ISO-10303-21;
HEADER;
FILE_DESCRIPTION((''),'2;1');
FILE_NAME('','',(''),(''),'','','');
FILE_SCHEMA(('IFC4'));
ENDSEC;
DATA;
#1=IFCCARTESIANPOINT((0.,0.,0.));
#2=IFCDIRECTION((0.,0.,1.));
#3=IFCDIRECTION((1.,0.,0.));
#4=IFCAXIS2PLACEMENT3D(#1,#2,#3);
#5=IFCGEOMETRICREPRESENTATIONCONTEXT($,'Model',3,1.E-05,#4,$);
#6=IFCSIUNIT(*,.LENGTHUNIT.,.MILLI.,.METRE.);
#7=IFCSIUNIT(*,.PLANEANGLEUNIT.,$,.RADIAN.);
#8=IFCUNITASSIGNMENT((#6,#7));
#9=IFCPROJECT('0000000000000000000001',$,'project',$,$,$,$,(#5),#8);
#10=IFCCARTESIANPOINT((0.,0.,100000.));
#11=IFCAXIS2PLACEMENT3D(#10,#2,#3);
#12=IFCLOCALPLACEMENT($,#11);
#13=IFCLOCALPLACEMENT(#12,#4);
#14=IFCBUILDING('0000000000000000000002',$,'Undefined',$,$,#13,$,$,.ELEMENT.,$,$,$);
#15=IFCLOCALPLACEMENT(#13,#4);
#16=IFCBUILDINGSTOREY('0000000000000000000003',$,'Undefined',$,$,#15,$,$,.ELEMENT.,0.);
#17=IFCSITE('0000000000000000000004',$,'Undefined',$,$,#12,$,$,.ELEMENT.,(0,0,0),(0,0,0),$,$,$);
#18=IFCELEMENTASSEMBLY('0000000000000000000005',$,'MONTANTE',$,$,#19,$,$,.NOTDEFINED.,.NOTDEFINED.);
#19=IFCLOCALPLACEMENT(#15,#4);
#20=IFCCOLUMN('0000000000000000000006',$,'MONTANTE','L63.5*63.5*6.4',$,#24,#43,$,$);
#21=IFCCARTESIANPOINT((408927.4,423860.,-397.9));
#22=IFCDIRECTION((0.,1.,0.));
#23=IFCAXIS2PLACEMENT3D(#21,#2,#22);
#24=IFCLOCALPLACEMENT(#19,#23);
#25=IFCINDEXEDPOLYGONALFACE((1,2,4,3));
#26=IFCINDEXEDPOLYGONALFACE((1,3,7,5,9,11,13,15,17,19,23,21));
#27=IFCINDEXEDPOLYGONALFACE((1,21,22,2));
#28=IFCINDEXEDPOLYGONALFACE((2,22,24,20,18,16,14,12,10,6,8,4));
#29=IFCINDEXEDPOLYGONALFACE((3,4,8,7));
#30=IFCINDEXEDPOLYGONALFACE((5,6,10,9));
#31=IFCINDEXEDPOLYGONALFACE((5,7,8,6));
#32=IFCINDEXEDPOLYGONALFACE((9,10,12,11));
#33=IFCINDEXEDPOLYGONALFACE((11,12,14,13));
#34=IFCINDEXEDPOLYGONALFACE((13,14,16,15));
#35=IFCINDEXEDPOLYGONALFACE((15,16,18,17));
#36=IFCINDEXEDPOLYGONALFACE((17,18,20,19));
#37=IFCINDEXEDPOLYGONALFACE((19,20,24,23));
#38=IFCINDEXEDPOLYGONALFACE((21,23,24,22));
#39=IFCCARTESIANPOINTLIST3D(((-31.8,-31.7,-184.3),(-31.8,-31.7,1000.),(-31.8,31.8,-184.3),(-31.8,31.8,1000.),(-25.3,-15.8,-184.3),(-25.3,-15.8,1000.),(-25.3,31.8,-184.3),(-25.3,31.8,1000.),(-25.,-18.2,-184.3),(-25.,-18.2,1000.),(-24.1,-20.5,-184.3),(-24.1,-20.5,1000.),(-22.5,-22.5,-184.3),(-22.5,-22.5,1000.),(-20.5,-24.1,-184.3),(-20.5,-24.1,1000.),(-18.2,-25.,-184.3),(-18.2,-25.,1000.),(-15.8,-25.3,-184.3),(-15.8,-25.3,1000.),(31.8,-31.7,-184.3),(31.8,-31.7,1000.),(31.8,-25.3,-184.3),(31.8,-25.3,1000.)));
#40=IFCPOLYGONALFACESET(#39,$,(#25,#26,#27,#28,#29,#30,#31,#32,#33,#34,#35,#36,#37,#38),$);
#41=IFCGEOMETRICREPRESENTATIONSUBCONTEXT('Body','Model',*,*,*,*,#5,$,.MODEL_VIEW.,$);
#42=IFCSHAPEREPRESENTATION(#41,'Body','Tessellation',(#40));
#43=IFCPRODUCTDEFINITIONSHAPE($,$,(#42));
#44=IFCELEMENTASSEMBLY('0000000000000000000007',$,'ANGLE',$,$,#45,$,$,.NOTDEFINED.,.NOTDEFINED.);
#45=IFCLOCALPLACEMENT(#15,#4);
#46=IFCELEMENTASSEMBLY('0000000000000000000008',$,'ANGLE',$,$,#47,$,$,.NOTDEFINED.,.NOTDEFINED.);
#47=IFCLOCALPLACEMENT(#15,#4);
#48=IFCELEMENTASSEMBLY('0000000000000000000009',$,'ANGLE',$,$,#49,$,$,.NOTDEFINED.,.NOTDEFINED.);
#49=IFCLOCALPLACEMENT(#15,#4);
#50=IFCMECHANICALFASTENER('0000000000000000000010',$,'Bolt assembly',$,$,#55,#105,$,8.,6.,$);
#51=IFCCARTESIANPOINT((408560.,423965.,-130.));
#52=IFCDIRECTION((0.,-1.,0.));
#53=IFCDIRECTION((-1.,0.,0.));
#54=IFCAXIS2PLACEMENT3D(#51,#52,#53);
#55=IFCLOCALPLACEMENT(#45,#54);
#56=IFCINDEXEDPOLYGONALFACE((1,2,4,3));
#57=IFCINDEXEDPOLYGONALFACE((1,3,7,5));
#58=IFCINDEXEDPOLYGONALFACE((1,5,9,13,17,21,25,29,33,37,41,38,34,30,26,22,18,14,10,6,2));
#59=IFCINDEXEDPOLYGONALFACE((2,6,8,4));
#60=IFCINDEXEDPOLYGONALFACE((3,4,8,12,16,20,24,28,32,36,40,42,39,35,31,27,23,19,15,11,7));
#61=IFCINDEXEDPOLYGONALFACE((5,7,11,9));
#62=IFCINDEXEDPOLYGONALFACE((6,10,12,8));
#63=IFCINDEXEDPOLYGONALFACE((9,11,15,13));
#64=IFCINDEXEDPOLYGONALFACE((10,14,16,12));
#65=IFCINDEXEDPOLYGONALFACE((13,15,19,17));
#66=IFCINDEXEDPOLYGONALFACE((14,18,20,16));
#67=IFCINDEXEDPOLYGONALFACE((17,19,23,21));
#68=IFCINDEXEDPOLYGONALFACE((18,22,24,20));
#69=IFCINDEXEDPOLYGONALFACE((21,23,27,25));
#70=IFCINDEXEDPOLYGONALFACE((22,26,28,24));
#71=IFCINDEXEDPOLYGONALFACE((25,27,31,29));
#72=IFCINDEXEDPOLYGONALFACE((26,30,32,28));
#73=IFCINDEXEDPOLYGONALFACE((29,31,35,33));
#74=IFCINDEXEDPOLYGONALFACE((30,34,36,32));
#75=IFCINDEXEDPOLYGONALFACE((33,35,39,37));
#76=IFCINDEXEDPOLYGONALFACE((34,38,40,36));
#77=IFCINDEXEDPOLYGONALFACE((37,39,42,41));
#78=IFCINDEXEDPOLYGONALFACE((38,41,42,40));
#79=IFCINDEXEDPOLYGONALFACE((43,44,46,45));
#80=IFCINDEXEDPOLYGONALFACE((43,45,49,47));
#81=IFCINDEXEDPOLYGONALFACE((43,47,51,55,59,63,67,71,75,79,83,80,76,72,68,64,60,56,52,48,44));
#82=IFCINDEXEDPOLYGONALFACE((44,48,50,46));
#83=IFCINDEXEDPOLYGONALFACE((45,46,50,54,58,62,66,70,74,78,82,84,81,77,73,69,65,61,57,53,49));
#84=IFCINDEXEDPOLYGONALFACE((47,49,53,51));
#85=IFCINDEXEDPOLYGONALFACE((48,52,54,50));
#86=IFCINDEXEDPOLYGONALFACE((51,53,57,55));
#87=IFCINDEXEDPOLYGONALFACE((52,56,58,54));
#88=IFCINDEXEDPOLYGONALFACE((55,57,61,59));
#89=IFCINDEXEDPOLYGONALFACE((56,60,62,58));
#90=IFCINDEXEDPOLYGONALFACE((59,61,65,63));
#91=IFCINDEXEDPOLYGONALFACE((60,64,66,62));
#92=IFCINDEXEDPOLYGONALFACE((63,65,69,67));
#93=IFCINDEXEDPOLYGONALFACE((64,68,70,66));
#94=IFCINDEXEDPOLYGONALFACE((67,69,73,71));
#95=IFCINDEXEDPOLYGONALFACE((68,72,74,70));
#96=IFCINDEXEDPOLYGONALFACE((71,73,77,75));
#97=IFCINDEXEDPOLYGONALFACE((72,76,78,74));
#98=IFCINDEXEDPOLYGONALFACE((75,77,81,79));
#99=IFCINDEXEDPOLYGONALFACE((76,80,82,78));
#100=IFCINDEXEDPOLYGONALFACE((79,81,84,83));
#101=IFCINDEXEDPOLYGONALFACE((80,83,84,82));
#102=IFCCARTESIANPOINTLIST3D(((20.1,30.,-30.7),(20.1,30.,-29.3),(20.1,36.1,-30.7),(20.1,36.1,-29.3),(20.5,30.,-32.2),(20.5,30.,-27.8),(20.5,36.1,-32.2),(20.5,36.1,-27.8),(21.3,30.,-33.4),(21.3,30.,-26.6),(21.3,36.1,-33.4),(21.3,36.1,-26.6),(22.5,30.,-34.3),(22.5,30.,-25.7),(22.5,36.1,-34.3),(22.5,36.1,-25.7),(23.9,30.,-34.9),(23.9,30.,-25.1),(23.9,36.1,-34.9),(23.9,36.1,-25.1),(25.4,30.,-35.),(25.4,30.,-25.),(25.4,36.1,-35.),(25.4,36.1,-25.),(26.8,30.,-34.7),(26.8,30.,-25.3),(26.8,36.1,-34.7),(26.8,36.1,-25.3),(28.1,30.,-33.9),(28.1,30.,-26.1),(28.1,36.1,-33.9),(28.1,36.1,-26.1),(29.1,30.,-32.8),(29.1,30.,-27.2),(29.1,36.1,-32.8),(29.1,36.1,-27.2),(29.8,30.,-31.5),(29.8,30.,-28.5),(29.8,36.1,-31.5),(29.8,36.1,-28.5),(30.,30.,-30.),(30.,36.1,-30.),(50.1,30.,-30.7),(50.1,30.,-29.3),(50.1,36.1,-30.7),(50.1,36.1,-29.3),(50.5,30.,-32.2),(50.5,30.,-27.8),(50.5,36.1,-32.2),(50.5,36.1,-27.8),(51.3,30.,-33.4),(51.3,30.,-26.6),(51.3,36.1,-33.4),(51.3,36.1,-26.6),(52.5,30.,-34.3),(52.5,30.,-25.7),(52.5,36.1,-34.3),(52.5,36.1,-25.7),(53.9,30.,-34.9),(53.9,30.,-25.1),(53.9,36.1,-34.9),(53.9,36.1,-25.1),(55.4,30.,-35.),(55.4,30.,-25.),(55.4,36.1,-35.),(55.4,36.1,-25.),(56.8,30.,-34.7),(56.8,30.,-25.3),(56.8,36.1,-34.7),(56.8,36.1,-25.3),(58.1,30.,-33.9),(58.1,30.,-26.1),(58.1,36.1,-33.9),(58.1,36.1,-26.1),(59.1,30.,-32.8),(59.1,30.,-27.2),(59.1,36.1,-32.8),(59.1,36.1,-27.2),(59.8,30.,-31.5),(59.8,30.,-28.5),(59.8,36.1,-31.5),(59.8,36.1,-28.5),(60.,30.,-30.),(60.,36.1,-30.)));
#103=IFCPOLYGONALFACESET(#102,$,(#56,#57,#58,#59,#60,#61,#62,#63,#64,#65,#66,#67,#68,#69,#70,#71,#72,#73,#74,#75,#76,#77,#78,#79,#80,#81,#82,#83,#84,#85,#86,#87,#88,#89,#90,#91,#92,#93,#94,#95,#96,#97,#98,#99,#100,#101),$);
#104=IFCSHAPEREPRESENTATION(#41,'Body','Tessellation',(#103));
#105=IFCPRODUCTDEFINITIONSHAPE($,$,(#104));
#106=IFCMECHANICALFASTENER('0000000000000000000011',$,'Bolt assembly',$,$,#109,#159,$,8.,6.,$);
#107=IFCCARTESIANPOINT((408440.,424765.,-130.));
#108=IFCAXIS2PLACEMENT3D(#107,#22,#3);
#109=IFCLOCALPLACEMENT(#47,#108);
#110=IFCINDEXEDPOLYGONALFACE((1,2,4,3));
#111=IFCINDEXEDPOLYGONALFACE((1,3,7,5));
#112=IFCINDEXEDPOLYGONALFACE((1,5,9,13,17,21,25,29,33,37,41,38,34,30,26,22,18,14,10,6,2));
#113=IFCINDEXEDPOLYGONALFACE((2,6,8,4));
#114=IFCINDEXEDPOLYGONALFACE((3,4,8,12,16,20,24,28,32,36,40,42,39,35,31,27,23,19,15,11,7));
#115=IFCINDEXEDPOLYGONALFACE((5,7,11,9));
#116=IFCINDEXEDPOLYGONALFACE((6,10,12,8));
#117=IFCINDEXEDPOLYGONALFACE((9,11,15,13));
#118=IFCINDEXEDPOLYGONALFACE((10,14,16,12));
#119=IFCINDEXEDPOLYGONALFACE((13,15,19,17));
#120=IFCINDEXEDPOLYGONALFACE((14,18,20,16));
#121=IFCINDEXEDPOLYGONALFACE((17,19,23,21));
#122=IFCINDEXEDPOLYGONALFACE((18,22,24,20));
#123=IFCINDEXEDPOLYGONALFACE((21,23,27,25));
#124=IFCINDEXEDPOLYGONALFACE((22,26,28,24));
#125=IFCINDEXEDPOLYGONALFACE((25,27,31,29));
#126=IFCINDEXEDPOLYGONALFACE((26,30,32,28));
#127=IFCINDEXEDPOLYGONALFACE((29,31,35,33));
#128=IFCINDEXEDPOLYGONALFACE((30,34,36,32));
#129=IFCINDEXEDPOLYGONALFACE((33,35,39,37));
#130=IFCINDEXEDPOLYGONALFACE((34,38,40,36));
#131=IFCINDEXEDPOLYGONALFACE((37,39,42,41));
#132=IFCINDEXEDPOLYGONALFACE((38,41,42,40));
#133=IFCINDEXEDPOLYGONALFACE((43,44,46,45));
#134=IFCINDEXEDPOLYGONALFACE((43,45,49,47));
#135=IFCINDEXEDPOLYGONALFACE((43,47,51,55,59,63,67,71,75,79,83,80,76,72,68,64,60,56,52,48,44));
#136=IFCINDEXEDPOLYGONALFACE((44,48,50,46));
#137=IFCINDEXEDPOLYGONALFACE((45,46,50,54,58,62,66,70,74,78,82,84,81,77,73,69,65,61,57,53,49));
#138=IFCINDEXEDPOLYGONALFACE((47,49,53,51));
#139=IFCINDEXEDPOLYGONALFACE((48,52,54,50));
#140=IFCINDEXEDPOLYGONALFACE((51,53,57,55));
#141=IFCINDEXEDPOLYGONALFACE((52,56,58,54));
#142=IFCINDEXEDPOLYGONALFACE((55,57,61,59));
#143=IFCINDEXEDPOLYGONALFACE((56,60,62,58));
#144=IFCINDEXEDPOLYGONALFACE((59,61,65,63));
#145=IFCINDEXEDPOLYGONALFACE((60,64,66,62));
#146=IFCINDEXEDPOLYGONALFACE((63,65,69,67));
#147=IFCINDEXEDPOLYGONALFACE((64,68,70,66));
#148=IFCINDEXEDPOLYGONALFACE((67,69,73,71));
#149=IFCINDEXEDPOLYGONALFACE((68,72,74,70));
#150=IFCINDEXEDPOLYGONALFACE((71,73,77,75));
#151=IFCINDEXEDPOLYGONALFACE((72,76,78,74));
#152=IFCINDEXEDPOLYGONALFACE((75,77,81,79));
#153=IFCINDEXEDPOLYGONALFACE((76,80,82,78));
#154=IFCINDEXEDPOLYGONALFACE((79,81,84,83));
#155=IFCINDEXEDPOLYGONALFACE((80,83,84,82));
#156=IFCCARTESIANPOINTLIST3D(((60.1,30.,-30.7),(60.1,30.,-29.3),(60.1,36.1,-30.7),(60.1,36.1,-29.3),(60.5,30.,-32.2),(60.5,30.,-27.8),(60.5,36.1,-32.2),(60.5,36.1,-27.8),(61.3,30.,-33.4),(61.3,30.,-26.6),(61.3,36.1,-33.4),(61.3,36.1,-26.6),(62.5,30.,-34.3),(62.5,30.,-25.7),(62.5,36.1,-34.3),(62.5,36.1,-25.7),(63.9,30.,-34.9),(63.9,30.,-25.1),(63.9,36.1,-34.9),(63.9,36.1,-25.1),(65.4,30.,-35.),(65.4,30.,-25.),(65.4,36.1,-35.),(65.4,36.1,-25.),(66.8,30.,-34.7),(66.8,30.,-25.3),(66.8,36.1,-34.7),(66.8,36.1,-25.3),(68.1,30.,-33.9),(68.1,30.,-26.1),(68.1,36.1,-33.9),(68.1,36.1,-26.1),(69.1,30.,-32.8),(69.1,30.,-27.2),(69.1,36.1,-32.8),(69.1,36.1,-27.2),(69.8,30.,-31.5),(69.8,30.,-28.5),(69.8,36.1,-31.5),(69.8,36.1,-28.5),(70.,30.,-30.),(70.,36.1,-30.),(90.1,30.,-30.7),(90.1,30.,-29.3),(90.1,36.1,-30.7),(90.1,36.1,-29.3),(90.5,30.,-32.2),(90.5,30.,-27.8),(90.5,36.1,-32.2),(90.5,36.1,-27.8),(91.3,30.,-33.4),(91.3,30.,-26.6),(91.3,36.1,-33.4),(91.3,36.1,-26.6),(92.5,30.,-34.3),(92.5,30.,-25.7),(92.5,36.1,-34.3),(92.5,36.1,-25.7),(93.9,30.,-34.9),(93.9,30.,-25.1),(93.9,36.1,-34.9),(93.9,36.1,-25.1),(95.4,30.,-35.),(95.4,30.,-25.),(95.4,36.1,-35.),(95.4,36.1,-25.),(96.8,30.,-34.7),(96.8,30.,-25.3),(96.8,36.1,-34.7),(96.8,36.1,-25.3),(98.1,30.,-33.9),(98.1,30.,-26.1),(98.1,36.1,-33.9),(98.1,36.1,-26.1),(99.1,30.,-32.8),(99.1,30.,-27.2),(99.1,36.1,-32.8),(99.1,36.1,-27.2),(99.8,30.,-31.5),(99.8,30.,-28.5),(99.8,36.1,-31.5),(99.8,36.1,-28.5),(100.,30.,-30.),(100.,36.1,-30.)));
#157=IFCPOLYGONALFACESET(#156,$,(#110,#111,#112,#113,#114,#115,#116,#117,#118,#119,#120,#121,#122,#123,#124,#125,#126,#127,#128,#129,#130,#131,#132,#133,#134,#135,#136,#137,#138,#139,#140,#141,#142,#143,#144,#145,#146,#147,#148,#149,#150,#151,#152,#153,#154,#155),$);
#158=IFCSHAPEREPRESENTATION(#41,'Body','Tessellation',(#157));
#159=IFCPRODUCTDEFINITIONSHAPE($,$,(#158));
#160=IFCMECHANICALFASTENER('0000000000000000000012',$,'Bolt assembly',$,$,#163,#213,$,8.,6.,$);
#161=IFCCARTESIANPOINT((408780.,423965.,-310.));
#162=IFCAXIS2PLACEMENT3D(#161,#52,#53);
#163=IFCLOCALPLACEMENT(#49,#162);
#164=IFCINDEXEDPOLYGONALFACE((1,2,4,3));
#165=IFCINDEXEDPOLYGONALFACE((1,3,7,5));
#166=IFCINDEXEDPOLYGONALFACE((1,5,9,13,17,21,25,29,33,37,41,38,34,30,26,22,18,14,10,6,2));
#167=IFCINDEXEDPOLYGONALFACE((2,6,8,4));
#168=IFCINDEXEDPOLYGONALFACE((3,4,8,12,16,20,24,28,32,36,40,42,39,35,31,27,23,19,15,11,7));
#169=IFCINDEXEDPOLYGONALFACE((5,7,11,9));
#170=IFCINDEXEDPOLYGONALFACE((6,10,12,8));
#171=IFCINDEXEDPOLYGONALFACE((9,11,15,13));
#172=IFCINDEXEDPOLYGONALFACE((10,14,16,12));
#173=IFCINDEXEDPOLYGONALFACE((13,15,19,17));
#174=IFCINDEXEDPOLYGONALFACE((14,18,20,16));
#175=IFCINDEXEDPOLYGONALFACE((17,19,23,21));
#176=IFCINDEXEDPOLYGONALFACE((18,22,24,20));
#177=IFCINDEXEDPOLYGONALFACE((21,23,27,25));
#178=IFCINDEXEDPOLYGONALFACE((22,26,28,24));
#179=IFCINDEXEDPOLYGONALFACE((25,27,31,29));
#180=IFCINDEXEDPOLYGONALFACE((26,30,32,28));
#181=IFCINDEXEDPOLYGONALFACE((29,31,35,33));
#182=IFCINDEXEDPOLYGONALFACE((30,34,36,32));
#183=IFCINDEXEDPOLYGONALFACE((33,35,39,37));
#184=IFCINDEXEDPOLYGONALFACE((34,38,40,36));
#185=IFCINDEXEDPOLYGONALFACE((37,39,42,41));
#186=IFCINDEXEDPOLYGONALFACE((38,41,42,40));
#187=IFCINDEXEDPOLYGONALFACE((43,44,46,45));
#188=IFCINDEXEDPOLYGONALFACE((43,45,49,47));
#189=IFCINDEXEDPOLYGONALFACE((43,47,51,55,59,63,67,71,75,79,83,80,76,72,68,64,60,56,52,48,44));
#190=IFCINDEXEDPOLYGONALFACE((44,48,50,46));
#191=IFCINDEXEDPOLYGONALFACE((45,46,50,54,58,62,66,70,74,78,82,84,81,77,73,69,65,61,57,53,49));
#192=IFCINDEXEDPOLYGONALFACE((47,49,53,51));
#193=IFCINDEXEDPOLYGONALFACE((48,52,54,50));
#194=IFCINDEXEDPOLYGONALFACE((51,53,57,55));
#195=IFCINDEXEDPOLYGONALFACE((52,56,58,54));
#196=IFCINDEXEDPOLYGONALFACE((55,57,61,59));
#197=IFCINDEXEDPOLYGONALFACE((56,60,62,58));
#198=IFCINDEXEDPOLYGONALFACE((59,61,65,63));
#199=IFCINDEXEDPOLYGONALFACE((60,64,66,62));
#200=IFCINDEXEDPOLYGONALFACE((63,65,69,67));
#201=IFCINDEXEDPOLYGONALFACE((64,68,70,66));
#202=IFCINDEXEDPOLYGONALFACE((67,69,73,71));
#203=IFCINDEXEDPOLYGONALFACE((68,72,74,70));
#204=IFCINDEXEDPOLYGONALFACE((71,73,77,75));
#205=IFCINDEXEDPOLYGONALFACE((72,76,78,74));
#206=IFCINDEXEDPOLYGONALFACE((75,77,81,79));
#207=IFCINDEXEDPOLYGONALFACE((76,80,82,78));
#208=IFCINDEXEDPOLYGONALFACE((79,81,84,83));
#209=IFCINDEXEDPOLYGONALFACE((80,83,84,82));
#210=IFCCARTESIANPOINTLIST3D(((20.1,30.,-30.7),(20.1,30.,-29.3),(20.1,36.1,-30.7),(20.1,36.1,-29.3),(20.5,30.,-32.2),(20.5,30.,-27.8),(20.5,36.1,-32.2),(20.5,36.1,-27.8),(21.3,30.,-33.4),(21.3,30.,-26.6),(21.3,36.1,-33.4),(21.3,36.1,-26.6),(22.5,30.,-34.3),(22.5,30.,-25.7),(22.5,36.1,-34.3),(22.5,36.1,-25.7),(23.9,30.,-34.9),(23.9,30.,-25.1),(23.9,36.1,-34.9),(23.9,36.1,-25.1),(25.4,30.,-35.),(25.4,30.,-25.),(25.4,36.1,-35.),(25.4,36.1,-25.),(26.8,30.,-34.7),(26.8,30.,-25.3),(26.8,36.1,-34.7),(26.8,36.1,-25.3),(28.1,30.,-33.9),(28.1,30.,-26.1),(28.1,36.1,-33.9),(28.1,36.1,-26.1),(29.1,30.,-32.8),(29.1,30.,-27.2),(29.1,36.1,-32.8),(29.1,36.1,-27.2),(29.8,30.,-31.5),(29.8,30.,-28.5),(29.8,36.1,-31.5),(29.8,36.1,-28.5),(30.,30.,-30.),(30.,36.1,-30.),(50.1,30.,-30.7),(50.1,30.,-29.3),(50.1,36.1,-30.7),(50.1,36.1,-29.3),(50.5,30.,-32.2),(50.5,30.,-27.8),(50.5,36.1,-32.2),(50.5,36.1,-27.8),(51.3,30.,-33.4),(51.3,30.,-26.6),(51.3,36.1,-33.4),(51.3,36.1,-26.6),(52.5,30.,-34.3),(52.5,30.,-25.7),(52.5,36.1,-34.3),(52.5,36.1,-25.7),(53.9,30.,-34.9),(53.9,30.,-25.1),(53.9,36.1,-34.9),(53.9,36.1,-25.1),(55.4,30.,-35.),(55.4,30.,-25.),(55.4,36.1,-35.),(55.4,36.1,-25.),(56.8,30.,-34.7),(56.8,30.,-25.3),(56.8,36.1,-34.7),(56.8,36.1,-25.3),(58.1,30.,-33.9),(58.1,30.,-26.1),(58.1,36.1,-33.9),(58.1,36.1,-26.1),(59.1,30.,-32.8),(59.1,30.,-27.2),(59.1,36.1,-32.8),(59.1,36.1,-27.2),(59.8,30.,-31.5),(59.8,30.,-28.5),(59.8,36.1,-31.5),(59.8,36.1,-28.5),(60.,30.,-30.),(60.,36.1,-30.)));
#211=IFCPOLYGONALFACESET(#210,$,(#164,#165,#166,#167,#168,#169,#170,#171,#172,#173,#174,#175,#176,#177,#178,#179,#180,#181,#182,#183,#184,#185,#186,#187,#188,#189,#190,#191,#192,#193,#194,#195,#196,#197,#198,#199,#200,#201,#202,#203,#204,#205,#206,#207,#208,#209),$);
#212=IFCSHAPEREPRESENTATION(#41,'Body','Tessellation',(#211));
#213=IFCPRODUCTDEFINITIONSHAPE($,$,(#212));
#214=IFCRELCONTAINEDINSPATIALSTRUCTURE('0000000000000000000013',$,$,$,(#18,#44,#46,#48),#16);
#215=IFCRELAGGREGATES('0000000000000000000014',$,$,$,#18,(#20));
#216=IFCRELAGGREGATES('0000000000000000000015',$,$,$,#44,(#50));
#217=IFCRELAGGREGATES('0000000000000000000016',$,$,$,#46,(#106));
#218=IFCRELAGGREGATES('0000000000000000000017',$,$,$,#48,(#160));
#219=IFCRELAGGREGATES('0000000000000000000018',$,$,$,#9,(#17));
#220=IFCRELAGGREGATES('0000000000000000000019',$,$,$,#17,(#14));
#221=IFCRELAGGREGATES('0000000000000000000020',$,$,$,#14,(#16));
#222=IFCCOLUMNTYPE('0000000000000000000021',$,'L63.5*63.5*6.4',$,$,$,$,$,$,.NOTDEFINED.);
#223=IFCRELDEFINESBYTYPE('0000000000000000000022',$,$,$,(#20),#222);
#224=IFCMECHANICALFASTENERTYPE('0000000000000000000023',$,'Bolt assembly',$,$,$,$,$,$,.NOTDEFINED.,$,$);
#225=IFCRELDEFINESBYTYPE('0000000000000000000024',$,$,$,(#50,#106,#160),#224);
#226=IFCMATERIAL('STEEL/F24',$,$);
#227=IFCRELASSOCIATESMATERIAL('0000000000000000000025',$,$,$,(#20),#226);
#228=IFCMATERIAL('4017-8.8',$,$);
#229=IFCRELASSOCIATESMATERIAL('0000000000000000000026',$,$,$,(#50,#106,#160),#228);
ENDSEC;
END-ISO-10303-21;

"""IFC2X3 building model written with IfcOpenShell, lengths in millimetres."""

from ifc_helpers import new_model, si_unit, frame, origin_with_axes, origin_2d_with_axis, place, context, subcontext, project, spatial, circle, l_section, extrude, clip, halfspace, source, transform, mapped, material, type_object, element, aggregate, save


model = new_model("IFC2X3")

# Units and contexts
model_context = context("Model", 3, precision=1e-05, world=origin_with_axes())
body_context = subcontext(model_context, "Body", "Model", "MODEL_VIEW")
ifc_project = project(units=[si_unit("LENGTHUNIT", "METRE", prefix="MILLI"), si_unit("PLANEANGLEUNIT", "RADIAN")], contexts=[model_context])

# Site, building, storey
site_placement = place(None, frame((0.0, 0.0, 100000.0), z_axis=(0.0, 0.0, 1.0), x_axis=(1.0, 0.0, 0.0)))
site = spatial("IfcSite", under=ifc_project, at=site_placement, Name="Undefined", CompositionType="ELEMENT", RefLatitude=(0, 0, 0), RefLongitude=(0, 0, 0))
building_placement = place(site_placement, origin_with_axes())
building = spatial("IfcBuilding", under=site, at=building_placement, Name="Undefined", CompositionType="ELEMENT")
storey_placement = place(building_placement, origin_with_axes())
storey = spatial("IfcBuildingStorey", under=building, at=storey_placement, Name="Undefined", CompositionType="ELEMENT", Elevation=0.0)

# Element assembly, column
assembly_1_placement = place(storey_placement, origin_with_axes())
assembly_1 = element("IfcElementAssembly", 1, at=assembly_1_placement, inside=storey, Name="MONTANTE", AssemblyPlace="NOTDEFINED", PredefinedType="NOTDEFINED")
ifc_material_1 = material(Name="STEEL/F24")
column_type_1 = type_object("IfcColumnType", Name="L63.5*63.5*6.4", PredefinedType="NOTDEFINED")
column_1_placement = place(assembly_1_placement, frame((408927.4, 423860.0, -397.9), z_axis=(0.0, 0.0, 1.0), x_axis=(0.0, 1.0, 0.0)))
column_1 = element("IfcColumn", 2, at=column_1_placement, type_object=column_type_1, material=ifc_material_1, Name="MONTANTE", Description="L63.5*63.5*6.4", context=body_context, shape_type="Clipping", body=[
    clip(extrude(l_section(Depth=63.5, Width=63.5, Thickness=6.4, FilletRadius=9.6, at=origin_2d_with_axis()), frame((0.0, 0.0, 1000.0), z_axis=(0.0, 0.0, -1.0), x_axis=(0.0, 1.0, 0.0)), (0.0, 0.0, 1.0), 1184.3), halfspace(frame((0.0, 0.0, -184.3), z_axis=(0.0, 0.0, -1.0), x_axis=(0.0, -1.0, 0.0)), False)),
])

# Element assemblies
assembly_2_placement = place(storey_placement, origin_with_axes())
assembly_2 = element("IfcElementAssembly", 3, at=assembly_2_placement, inside=storey, Name="ANGLE", AssemblyPlace="NOTDEFINED", PredefinedType="NOTDEFINED")
assembly_3_placement = place(storey_placement, origin_with_axes())
assembly_3 = element("IfcElementAssembly", 4, at=assembly_3_placement, inside=storey, Name="ANGLE", AssemblyPlace="NOTDEFINED", PredefinedType="NOTDEFINED")
assembly_4_placement = place(storey_placement, origin_with_axes())
assembly_4 = element("IfcElementAssembly", 5, at=assembly_4_placement, inside=storey, Name="ANGLE", AssemblyPlace="NOTDEFINED", PredefinedType="NOTDEFINED")

# Shared definitions
ifc_material_2 = material(Name="4017-8.8")
mechanical_fastener_type = type_object("IfcMechanicalFastenerType", Name="Bolt assembly")
aggregate(assembly_1, [column_1])

# Mechanical fasteners
shared_shape_1 = source(origin_with_axes(), body_context, "Body", "SweptSolid", [
    extrude(circle(Radius=5.0, at=origin_2d_with_axis()), frame((0.0, 30.0, 0.0), z_axis=(0.0, 1.0, 0.0), x_axis=(1.0, 0.0, 0.0)), (0.0, 0.0, 1.0), 6.1),
])
mechanical_fastener_1_placement = place(assembly_2_placement, frame((408560.0, 423965.0, -130.0), z_axis=(0.0, -1.0, 0.0), x_axis=(-1.0, 0.0, 0.0)))
mechanical_fastener_1 = element("IfcMechanicalFastener", 6, at=mechanical_fastener_1_placement, type_object=mechanical_fastener_type, material=ifc_material_2, Name="Bolt assembly", NominalDiameter=8.0, NominalLength=6.0, context=body_context, shape_type="MappedRepresentation", body=[
    mapped(shared_shape_1, transform((25.0, 0.0, -30.0))),
    mapped(shared_shape_1, transform((55.0, 0.0, -30.0))),
])
aggregate(assembly_2, [mechanical_fastener_1])
mechanical_fastener_2_placement = place(assembly_3_placement, frame((408440.0, 424765.0, -130.0), z_axis=(0.0, 1.0, 0.0), x_axis=(1.0, 0.0, 0.0)))
mechanical_fastener_2 = element("IfcMechanicalFastener", 7, at=mechanical_fastener_2_placement, type_object=mechanical_fastener_type, material=ifc_material_2, Name="Bolt assembly", NominalDiameter=8.0, NominalLength=6.0, context=body_context, shape_type="MappedRepresentation", body=[
    mapped(shared_shape_1, transform((95.0, 0.0, -30.0))),
    mapped(shared_shape_1, transform((65.0, 0.0, -30.0))),
])
aggregate(assembly_3, [mechanical_fastener_2])
mechanical_fastener_3_placement = place(assembly_4_placement, frame((408780.0, 423965.0, -310.0), z_axis=(0.0, -1.0, 0.0), x_axis=(-1.0, 0.0, 0.0)))
mechanical_fastener_3 = element("IfcMechanicalFastener", 8, at=mechanical_fastener_3_placement, type_object=mechanical_fastener_type, material=ifc_material_2, Name="Bolt assembly", NominalDiameter=8.0, NominalLength=6.0, context=body_context, shape_type="MappedRepresentation", body=[
    mapped(shared_shape_1, transform((25.0, 0.0, -30.0))),
    mapped(shared_shape_1, transform((55.0, 0.0, -30.0))),
])
aggregate(assembly_4, [mechanical_fastener_3])

save(model, "model.ifc")
